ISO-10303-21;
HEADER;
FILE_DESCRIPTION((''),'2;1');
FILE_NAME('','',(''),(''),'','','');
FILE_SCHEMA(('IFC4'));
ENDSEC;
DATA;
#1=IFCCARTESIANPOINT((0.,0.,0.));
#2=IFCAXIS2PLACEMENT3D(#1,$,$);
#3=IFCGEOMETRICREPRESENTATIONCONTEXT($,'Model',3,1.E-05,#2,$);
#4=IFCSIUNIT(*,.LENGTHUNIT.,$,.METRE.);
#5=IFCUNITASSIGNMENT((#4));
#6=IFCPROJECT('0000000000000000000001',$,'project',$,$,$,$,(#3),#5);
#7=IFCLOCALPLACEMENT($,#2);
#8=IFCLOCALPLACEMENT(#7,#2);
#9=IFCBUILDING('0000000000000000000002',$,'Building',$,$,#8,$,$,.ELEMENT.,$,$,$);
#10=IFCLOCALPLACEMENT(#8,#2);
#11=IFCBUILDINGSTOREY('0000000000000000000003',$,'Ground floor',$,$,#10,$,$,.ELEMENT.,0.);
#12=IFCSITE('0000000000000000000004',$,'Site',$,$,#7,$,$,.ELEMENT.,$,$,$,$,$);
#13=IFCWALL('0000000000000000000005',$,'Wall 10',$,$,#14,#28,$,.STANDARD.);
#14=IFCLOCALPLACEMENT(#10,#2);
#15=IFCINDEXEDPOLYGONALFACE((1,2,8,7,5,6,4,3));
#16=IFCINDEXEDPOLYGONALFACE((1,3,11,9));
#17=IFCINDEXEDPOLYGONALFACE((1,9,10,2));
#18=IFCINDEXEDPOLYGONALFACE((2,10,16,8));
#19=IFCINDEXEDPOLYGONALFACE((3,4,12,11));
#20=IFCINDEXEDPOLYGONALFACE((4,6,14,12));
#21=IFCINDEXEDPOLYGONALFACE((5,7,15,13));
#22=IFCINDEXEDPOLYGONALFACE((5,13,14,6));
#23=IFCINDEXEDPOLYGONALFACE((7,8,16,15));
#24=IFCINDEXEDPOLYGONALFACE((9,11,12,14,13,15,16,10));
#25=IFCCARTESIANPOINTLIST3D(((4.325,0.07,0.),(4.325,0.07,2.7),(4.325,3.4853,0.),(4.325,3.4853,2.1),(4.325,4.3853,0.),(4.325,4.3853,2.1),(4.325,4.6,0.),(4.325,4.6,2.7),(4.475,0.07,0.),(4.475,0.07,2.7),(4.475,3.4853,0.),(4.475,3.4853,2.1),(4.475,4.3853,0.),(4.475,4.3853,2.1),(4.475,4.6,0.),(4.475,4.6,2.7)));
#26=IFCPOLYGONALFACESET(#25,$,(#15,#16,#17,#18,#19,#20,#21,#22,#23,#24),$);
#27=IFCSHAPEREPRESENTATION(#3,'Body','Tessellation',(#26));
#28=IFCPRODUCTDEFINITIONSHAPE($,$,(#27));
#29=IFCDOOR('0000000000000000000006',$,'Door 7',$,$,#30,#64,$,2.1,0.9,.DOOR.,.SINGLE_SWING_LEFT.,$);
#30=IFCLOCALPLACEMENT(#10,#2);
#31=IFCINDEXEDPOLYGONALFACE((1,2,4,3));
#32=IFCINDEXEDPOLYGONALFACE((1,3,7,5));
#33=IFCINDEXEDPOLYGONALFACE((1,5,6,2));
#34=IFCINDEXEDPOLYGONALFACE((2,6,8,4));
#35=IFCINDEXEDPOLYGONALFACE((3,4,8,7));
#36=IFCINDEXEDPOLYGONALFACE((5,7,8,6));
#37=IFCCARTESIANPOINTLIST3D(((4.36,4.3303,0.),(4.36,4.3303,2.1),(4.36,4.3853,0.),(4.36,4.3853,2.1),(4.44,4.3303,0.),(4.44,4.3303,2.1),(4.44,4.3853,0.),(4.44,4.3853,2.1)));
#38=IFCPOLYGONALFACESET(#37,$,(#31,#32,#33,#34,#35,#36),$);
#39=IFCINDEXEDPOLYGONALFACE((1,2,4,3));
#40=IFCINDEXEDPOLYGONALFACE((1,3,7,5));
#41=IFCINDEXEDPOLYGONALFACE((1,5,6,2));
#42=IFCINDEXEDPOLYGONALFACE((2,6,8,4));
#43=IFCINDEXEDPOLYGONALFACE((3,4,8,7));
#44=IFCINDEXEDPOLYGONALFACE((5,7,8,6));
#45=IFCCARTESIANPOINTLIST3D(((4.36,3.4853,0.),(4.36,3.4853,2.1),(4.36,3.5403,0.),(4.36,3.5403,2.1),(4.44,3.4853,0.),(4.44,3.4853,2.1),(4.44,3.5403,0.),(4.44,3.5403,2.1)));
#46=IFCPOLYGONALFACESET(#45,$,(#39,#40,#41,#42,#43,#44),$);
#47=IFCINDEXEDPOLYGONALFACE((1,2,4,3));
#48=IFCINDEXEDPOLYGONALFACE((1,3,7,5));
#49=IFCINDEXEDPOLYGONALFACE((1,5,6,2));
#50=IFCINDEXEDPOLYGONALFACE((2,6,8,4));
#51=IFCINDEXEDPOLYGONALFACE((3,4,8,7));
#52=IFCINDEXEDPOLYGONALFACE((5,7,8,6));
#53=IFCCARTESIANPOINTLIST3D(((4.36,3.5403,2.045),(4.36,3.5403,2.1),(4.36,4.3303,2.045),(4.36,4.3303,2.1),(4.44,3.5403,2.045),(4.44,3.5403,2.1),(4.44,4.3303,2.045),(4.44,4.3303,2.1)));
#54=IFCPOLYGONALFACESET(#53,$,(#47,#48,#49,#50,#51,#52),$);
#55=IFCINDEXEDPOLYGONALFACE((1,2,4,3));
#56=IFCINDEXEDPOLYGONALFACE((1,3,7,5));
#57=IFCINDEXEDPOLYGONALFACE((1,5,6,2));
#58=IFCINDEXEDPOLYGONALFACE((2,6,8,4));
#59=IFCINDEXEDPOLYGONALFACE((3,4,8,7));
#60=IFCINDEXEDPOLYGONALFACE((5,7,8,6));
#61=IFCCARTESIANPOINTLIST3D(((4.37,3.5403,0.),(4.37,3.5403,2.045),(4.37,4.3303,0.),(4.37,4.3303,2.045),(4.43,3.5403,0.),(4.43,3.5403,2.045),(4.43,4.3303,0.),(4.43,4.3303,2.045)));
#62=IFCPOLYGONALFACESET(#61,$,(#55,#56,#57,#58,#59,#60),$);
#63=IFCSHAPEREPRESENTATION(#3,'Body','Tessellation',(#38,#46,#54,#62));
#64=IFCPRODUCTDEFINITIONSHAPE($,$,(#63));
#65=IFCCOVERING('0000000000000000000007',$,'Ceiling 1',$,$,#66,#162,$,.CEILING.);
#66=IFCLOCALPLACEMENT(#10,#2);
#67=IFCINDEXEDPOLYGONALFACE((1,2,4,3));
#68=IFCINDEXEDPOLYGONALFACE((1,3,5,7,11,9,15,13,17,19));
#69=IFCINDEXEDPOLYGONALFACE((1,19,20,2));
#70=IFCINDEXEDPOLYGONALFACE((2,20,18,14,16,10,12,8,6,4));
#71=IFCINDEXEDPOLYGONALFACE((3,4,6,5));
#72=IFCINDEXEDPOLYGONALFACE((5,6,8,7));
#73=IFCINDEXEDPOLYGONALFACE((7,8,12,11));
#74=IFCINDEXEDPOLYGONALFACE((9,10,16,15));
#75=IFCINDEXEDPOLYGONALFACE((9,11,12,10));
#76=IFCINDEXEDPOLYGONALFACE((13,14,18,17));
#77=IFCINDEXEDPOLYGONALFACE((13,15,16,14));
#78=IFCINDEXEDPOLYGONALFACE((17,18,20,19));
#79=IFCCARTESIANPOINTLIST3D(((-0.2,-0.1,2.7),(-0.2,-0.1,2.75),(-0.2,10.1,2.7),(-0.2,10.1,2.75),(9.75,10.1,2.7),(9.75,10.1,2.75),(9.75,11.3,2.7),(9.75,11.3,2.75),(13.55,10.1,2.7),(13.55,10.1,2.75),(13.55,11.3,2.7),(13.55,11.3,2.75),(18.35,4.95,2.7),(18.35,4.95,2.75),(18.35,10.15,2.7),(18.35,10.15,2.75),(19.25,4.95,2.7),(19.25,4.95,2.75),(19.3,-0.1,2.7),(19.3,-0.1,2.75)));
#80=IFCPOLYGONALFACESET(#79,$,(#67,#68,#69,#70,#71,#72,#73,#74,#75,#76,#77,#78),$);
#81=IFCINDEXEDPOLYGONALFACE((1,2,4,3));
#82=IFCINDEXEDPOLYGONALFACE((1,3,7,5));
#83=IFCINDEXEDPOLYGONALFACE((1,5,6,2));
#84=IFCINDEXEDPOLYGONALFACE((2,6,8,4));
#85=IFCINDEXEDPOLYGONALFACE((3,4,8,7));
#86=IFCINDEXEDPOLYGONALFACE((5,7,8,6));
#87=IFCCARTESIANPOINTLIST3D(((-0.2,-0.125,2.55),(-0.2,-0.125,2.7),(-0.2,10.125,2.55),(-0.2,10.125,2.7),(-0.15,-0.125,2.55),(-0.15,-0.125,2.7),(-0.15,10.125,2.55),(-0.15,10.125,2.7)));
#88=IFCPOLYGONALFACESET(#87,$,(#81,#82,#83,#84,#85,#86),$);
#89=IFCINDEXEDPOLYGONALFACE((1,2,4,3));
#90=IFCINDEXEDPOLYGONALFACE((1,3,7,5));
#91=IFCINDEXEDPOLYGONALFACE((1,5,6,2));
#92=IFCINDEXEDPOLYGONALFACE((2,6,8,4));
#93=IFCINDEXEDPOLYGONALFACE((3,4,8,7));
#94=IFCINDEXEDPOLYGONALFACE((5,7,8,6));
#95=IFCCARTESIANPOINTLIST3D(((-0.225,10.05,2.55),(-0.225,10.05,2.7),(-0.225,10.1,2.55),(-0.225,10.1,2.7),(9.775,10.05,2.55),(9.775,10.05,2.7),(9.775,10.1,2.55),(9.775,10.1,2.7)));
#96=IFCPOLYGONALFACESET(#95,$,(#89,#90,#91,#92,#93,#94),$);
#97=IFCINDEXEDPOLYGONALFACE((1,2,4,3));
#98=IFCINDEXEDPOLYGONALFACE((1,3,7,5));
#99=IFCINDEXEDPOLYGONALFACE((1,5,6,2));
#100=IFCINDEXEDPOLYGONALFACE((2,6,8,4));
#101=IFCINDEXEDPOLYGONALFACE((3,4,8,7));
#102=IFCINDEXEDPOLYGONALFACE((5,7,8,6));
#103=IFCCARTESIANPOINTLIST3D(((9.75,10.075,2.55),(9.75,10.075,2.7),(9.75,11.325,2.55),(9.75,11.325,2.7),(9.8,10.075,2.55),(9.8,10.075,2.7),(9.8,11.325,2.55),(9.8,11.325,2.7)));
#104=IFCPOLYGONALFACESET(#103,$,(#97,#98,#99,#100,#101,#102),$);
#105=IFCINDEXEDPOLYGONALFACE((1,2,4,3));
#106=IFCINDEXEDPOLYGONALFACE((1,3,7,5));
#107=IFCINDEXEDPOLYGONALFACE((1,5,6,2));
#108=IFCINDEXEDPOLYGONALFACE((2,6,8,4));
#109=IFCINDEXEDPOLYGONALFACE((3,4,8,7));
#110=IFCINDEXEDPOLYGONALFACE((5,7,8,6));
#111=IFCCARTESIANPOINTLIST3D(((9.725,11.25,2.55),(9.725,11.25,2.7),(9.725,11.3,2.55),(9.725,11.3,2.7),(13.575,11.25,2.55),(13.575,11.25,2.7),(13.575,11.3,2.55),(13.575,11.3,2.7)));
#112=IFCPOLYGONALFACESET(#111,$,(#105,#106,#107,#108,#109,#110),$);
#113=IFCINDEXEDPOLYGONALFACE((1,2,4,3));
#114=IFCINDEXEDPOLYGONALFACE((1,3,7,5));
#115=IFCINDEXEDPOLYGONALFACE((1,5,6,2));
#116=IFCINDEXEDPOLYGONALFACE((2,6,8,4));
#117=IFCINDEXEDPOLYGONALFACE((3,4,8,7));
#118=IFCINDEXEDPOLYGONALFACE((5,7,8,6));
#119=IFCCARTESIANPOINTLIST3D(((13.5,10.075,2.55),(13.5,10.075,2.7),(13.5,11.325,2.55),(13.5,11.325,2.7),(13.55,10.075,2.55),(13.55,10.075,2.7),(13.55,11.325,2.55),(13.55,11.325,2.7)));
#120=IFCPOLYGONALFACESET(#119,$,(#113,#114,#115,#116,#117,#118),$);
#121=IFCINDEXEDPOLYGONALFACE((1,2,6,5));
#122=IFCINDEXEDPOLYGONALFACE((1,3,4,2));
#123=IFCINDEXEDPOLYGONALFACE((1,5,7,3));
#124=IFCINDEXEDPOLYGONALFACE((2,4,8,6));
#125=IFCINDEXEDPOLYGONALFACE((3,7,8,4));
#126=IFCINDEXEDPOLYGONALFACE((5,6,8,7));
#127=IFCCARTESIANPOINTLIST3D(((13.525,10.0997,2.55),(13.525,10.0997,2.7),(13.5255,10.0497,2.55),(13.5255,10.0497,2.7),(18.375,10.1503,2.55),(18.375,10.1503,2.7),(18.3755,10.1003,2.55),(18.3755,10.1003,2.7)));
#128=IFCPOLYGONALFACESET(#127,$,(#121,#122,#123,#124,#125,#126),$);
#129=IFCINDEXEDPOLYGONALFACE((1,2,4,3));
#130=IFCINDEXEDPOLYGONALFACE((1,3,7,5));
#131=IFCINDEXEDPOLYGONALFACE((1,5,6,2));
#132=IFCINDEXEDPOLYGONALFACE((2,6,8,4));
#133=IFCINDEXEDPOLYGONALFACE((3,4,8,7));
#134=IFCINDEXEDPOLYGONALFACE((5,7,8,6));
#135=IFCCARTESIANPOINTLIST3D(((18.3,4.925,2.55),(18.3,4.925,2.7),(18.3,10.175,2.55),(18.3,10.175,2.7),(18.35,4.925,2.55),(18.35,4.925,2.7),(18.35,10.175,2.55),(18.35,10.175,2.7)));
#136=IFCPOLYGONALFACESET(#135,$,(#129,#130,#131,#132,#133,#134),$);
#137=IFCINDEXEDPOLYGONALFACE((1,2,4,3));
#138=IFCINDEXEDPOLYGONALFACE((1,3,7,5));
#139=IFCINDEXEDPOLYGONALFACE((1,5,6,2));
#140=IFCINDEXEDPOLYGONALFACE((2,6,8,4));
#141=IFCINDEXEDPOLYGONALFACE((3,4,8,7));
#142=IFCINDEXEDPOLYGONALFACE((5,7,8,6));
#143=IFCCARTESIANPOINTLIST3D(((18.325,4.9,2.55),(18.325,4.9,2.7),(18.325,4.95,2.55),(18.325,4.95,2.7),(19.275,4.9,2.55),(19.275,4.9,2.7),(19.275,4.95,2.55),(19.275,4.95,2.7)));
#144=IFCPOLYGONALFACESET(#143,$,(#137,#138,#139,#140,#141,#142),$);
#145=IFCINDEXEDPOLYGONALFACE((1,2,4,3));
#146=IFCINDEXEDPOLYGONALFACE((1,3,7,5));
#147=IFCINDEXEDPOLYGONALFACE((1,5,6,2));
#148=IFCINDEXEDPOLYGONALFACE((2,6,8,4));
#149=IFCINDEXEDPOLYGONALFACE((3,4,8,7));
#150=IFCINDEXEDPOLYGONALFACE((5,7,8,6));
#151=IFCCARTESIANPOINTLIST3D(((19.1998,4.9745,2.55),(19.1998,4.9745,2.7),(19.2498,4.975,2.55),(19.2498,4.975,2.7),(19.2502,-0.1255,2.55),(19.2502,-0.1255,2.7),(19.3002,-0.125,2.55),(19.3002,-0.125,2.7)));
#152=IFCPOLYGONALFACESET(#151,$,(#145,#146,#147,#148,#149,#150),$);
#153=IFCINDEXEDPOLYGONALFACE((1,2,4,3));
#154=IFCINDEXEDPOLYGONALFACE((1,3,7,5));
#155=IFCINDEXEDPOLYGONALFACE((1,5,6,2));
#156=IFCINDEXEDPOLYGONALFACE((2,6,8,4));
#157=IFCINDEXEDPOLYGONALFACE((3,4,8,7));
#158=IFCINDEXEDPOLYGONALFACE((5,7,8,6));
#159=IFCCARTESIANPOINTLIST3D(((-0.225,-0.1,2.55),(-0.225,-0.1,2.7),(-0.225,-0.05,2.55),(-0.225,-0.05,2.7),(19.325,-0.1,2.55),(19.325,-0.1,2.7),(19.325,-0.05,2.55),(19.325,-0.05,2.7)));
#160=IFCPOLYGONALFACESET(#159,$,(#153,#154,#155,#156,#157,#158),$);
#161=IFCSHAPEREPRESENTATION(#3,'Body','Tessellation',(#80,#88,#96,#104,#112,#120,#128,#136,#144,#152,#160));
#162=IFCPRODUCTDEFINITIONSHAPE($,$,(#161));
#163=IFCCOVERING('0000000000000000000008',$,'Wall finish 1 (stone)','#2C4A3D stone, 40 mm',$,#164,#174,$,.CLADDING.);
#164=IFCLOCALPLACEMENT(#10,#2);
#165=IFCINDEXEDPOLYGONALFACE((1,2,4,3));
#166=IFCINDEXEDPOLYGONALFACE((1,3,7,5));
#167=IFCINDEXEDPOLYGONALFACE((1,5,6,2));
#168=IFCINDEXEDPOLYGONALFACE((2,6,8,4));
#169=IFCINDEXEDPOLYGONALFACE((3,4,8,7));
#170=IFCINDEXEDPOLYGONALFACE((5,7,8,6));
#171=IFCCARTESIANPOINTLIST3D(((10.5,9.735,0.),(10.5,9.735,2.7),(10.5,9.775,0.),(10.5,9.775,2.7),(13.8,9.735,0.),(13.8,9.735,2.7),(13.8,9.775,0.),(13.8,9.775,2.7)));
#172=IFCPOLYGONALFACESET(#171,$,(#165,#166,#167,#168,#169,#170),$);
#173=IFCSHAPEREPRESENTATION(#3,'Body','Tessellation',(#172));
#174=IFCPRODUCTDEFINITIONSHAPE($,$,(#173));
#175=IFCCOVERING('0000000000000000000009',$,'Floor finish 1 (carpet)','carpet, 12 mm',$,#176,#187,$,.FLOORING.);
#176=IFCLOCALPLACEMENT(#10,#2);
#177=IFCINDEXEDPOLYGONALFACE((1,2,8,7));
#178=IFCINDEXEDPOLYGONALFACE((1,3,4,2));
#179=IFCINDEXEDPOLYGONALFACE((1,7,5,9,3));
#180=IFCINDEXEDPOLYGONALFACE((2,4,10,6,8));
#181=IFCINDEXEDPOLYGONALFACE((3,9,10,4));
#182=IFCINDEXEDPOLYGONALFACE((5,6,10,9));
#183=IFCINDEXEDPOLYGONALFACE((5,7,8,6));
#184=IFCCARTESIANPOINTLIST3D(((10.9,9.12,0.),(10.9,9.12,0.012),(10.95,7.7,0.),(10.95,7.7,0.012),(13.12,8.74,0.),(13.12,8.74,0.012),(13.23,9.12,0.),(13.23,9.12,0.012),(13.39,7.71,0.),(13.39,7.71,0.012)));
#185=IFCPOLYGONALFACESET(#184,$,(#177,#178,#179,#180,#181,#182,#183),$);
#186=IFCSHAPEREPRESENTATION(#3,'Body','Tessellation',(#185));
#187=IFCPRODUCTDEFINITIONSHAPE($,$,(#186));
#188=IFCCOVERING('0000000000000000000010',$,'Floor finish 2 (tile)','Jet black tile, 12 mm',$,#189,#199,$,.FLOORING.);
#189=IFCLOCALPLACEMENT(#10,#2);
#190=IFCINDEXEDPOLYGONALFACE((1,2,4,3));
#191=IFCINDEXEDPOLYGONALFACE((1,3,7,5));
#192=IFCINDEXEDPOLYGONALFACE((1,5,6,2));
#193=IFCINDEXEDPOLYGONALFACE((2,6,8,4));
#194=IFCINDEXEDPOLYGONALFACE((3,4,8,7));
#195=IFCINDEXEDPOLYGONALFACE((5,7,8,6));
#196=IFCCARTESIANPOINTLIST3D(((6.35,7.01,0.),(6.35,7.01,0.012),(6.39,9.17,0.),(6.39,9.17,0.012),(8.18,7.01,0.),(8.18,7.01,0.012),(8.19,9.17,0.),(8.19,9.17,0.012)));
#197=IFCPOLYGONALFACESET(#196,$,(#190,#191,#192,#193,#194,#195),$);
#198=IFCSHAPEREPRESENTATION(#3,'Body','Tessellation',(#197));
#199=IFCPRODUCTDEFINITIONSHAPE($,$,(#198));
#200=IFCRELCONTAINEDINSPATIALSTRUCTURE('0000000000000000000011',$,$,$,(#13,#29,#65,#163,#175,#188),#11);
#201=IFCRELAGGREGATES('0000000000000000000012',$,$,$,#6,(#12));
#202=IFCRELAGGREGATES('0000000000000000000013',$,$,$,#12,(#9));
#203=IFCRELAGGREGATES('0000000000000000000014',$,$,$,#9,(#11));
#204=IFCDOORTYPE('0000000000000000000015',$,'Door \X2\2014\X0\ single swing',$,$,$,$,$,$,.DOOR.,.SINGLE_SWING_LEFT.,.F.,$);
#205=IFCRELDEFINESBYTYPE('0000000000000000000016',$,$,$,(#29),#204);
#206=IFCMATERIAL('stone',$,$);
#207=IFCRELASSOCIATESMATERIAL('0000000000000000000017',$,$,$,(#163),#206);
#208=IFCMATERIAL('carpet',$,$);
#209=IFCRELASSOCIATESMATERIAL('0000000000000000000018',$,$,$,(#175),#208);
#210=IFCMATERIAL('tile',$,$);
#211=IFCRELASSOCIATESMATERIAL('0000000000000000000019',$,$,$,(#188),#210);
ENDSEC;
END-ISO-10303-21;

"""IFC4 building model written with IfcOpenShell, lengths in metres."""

from ifc_helpers import new_model, si_unit, frame, frame_2d, origin, origin_with_axes, place, context, project, spatial, polyline, rectangle, outline, extrude, material, type_object, element, fill, save


model = new_model("IFC4")

# Units and contexts
model_context = context("Model", 3, precision=1e-05, world=origin())
ifc_project = project(units=[si_unit("LENGTHUNIT", "METRE")], contexts=[model_context])

# Site, building, storey
site_placement = place(None, origin())
site = spatial("IfcSite", under=ifc_project, at=site_placement, Name="Site", CompositionType="ELEMENT")
building_placement = place(site_placement, origin())
building = spatial("IfcBuilding", under=site, at=building_placement, Name="Building", CompositionType="ELEMENT")
storey_placement = place(building_placement, origin())
storey = spatial("IfcBuildingStorey", under=building, at=storey_placement, Name="Ground floor", CompositionType="ELEMENT", Elevation=0.0)

# Shared definitions
door_type_1 = type_object("IfcDoorType", Name="Door — single swing", OperationType="SINGLE_SWING_LEFT", ParameterTakesPrecedence=False, PredefinedType="DOOR")

# Wall, opening, door
wall_1_placement = place(storey_placement, frame((4.4, 4.6, 0.0), z_axis=(0.0, 0.0, 1.0), x_axis=(0.0, -1.0, 0.0)))
wall_1 = element("IfcWall", 1, at=wall_1_placement, inside=storey, Name="Wall 10", PredefinedType="STANDARD", context=model_context, shape_type="SweptSolid", body=[
    extrude(rectangle(XDim=4.53, YDim=0.15, at=frame_2d((2.265, 0.0))), origin(), (0.0, 0.0, 1.0), 2.7),
])
opening_1_placement = place(storey_placement, frame((4.4, 4.3853, 0.0), z_axis=(0.0, 0.0, 1.0), x_axis=(0.0, -1.0, 0.0)))
opening_1 = element("IfcOpeningElement", 2, at=opening_1_placement, cuts=wall_1, PredefinedType="OPENING", context=model_context, shape_type="SweptSolid", body=[
    extrude(rectangle(XDim=0.9, YDim=0.21, at=frame_2d((0.45, 0.0))), origin(), (0.0, 0.0, 1.0), 2.1),
])
door_1_placement = place(storey_placement, frame((4.4, 4.3853, 0.0), z_axis=(0.0, 0.0, 1.0), x_axis=(0.0, -1.0, 0.0)))
door_1 = element("IfcDoor", 3, at=door_1_placement, inside=storey, type_object=door_type_1, Name="Door 7", OperationType="SINGLE_SWING_LEFT", OverallHeight=2.1, OverallWidth=0.9, PredefinedType="DOOR", context=model_context, shape_type="SweptSolid", body=[
    extrude(rectangle(XDim=0.055, YDim=0.08, at=frame_2d((0.0275, 0.0))), origin(), (0.0, 0.0, 1.0), 2.1),
    extrude(rectangle(XDim=0.055, YDim=0.08, at=frame_2d((0.8725, 0.0))), origin(), (0.0, 0.0, 1.0), 2.1),
    extrude(rectangle(XDim=0.79, YDim=0.08, at=frame_2d((0.45, 0.0))), frame((0.0, 0.0, 2.045)), (0.0, 0.0, 1.0), 0.055),
    extrude(rectangle(XDim=0.79, YDim=0.06, at=frame_2d((0.45, 0.0))), origin(), (0.0, 0.0, 1.0), 2.045),
])
fill(opening_1, door_1)

# Coverings
covering_1_placement = place(storey_placement, frame((0.0, 0.0, 2.7), z_axis=(0.0, 0.0, 1.0), x_axis=(1.0, 0.0, 0.0)))
element("IfcCovering", 4, at=covering_1_placement, inside=storey, Name="Ceiling 1", PredefinedType="CEILING", context=model_context, shape_type="SweptSolid", body=[
    extrude(outline(polyline([(-0.2, -0.1), (-0.2, 10.1), (9.75, 10.1), (9.75, 11.3), (13.55, 11.3), (13.55, 10.1), (18.35, 10.15), (18.35, 4.95), (19.25, 4.95), (19.3, -0.1), (-0.2, -0.1)])), origin(), (0.0, 0.0, 1.0), 0.05),
    extrude(outline(polyline([(-0.15, -0.125), (-0.15, 10.125), (-0.2, 10.125), (-0.2, -0.125), (-0.15, -0.125)])), frame((0.0, 0.0, -0.15)), (0.0, 0.0, 1.0), 0.15),
    extrude(outline(polyline([(-0.225, 10.05), (9.775, 10.05), (9.775, 10.1), (-0.225, 10.1), (-0.225, 10.05)])), frame((0.0, 0.0, -0.15)), (0.0, 0.0, 1.0), 0.15),
    extrude(outline(polyline([(9.8, 10.075), (9.8, 11.325), (9.75, 11.325), (9.75, 10.075), (9.8, 10.075)])), frame((0.0, 0.0, -0.15)), (0.0, 0.0, 1.0), 0.15),
    extrude(outline(polyline([(9.725, 11.25), (13.575, 11.25), (13.575, 11.3), (9.725, 11.3), (9.725, 11.25)])), frame((0.0, 0.0, -0.15)), (0.0, 0.0, 1.0), 0.15),
    extrude(outline(polyline([(13.5, 11.325), (13.5, 10.075), (13.55, 10.075), (13.55, 11.325), (13.5, 11.325)])), frame((0.0, 0.0, -0.15)), (0.0, 0.0, 1.0), 0.15),
    extrude(outline(polyline([(13.5255, 10.0497), (18.3755, 10.1003), (18.375, 10.1503), (13.525, 10.0997), (13.5255, 10.0497)])), frame((0.0, 0.0, -0.15)), (0.0, 0.0, 1.0), 0.15),
    extrude(outline(polyline([(18.3, 10.175), (18.3, 4.925), (18.35, 4.925), (18.35, 10.175), (18.3, 10.175)])), frame((0.0, 0.0, -0.15)), (0.0, 0.0, 1.0), 0.15),
    extrude(outline(polyline([(18.325, 4.9), (19.275, 4.9), (19.275, 4.95), (18.325, 4.95), (18.325, 4.9)])), frame((0.0, 0.0, -0.15)), (0.0, 0.0, 1.0), 0.15),
    extrude(outline(polyline([(19.1998, 4.9745), (19.2503, -0.1255), (19.3002, -0.125), (19.2498, 4.975), (19.1998, 4.9745)])), frame((0.0, 0.0, -0.15)), (0.0, 0.0, 1.0), 0.15),
    extrude(outline(polyline([(19.325, -0.05), (-0.225, -0.05), (-0.225, -0.1), (19.325, -0.1), (19.325, -0.05)])), frame((0.0, 0.0, -0.15)), (0.0, 0.0, 1.0), 0.15),
])
ifc_material_1 = material(Name="stone")
covering_2_placement = place(storey_placement, origin_with_axes())
element("IfcCovering", 5, at=covering_2_placement, inside=storey, material=ifc_material_1, Name="Wall finish 1 (stone)", Description="#2C4A3D stone, 40 mm", PredefinedType="CLADDING", context=model_context, shape_type="SweptSolid", body=[
    extrude(outline(polyline([(10.5, 9.735), (13.8, 9.735), (13.8, 9.775), (10.5, 9.775), (10.5, 9.735)])), origin(), (0.0, 0.0, 1.0), 2.7),
])
ifc_material_2 = material(Name="carpet")
covering_3_placement = place(storey_placement, origin_with_axes())
element("IfcCovering", 6, at=covering_3_placement, inside=storey, material=ifc_material_2, Name="Floor finish 1 (carpet)", Description="carpet, 12 mm", PredefinedType="FLOORING", context=model_context, shape_type="SweptSolid", body=[
    extrude(outline(polyline([(13.23, 9.12), (10.9, 9.12), (10.95, 7.7), (13.39, 7.71), (13.12, 8.74), (13.23, 9.12)])), origin(), (0.0, 0.0, 1.0), 0.012),
])
ifc_material_3 = material(Name="tile")
covering_4_placement = place(storey_placement, origin_with_axes())
element("IfcCovering", 7, at=covering_4_placement, inside=storey, material=ifc_material_3, Name="Floor finish 2 (tile)", Description="Jet black tile, 12 mm", PredefinedType="FLOORING", context=model_context, shape_type="SweptSolid", body=[
    extrude(outline(polyline([(6.39, 9.17), (8.19, 9.17), (8.18, 7.01), (6.35, 7.01), (6.39, 9.17)])), origin(), (0.0, 0.0, 1.0), 0.012),
])

save(model, "model.ifc")
